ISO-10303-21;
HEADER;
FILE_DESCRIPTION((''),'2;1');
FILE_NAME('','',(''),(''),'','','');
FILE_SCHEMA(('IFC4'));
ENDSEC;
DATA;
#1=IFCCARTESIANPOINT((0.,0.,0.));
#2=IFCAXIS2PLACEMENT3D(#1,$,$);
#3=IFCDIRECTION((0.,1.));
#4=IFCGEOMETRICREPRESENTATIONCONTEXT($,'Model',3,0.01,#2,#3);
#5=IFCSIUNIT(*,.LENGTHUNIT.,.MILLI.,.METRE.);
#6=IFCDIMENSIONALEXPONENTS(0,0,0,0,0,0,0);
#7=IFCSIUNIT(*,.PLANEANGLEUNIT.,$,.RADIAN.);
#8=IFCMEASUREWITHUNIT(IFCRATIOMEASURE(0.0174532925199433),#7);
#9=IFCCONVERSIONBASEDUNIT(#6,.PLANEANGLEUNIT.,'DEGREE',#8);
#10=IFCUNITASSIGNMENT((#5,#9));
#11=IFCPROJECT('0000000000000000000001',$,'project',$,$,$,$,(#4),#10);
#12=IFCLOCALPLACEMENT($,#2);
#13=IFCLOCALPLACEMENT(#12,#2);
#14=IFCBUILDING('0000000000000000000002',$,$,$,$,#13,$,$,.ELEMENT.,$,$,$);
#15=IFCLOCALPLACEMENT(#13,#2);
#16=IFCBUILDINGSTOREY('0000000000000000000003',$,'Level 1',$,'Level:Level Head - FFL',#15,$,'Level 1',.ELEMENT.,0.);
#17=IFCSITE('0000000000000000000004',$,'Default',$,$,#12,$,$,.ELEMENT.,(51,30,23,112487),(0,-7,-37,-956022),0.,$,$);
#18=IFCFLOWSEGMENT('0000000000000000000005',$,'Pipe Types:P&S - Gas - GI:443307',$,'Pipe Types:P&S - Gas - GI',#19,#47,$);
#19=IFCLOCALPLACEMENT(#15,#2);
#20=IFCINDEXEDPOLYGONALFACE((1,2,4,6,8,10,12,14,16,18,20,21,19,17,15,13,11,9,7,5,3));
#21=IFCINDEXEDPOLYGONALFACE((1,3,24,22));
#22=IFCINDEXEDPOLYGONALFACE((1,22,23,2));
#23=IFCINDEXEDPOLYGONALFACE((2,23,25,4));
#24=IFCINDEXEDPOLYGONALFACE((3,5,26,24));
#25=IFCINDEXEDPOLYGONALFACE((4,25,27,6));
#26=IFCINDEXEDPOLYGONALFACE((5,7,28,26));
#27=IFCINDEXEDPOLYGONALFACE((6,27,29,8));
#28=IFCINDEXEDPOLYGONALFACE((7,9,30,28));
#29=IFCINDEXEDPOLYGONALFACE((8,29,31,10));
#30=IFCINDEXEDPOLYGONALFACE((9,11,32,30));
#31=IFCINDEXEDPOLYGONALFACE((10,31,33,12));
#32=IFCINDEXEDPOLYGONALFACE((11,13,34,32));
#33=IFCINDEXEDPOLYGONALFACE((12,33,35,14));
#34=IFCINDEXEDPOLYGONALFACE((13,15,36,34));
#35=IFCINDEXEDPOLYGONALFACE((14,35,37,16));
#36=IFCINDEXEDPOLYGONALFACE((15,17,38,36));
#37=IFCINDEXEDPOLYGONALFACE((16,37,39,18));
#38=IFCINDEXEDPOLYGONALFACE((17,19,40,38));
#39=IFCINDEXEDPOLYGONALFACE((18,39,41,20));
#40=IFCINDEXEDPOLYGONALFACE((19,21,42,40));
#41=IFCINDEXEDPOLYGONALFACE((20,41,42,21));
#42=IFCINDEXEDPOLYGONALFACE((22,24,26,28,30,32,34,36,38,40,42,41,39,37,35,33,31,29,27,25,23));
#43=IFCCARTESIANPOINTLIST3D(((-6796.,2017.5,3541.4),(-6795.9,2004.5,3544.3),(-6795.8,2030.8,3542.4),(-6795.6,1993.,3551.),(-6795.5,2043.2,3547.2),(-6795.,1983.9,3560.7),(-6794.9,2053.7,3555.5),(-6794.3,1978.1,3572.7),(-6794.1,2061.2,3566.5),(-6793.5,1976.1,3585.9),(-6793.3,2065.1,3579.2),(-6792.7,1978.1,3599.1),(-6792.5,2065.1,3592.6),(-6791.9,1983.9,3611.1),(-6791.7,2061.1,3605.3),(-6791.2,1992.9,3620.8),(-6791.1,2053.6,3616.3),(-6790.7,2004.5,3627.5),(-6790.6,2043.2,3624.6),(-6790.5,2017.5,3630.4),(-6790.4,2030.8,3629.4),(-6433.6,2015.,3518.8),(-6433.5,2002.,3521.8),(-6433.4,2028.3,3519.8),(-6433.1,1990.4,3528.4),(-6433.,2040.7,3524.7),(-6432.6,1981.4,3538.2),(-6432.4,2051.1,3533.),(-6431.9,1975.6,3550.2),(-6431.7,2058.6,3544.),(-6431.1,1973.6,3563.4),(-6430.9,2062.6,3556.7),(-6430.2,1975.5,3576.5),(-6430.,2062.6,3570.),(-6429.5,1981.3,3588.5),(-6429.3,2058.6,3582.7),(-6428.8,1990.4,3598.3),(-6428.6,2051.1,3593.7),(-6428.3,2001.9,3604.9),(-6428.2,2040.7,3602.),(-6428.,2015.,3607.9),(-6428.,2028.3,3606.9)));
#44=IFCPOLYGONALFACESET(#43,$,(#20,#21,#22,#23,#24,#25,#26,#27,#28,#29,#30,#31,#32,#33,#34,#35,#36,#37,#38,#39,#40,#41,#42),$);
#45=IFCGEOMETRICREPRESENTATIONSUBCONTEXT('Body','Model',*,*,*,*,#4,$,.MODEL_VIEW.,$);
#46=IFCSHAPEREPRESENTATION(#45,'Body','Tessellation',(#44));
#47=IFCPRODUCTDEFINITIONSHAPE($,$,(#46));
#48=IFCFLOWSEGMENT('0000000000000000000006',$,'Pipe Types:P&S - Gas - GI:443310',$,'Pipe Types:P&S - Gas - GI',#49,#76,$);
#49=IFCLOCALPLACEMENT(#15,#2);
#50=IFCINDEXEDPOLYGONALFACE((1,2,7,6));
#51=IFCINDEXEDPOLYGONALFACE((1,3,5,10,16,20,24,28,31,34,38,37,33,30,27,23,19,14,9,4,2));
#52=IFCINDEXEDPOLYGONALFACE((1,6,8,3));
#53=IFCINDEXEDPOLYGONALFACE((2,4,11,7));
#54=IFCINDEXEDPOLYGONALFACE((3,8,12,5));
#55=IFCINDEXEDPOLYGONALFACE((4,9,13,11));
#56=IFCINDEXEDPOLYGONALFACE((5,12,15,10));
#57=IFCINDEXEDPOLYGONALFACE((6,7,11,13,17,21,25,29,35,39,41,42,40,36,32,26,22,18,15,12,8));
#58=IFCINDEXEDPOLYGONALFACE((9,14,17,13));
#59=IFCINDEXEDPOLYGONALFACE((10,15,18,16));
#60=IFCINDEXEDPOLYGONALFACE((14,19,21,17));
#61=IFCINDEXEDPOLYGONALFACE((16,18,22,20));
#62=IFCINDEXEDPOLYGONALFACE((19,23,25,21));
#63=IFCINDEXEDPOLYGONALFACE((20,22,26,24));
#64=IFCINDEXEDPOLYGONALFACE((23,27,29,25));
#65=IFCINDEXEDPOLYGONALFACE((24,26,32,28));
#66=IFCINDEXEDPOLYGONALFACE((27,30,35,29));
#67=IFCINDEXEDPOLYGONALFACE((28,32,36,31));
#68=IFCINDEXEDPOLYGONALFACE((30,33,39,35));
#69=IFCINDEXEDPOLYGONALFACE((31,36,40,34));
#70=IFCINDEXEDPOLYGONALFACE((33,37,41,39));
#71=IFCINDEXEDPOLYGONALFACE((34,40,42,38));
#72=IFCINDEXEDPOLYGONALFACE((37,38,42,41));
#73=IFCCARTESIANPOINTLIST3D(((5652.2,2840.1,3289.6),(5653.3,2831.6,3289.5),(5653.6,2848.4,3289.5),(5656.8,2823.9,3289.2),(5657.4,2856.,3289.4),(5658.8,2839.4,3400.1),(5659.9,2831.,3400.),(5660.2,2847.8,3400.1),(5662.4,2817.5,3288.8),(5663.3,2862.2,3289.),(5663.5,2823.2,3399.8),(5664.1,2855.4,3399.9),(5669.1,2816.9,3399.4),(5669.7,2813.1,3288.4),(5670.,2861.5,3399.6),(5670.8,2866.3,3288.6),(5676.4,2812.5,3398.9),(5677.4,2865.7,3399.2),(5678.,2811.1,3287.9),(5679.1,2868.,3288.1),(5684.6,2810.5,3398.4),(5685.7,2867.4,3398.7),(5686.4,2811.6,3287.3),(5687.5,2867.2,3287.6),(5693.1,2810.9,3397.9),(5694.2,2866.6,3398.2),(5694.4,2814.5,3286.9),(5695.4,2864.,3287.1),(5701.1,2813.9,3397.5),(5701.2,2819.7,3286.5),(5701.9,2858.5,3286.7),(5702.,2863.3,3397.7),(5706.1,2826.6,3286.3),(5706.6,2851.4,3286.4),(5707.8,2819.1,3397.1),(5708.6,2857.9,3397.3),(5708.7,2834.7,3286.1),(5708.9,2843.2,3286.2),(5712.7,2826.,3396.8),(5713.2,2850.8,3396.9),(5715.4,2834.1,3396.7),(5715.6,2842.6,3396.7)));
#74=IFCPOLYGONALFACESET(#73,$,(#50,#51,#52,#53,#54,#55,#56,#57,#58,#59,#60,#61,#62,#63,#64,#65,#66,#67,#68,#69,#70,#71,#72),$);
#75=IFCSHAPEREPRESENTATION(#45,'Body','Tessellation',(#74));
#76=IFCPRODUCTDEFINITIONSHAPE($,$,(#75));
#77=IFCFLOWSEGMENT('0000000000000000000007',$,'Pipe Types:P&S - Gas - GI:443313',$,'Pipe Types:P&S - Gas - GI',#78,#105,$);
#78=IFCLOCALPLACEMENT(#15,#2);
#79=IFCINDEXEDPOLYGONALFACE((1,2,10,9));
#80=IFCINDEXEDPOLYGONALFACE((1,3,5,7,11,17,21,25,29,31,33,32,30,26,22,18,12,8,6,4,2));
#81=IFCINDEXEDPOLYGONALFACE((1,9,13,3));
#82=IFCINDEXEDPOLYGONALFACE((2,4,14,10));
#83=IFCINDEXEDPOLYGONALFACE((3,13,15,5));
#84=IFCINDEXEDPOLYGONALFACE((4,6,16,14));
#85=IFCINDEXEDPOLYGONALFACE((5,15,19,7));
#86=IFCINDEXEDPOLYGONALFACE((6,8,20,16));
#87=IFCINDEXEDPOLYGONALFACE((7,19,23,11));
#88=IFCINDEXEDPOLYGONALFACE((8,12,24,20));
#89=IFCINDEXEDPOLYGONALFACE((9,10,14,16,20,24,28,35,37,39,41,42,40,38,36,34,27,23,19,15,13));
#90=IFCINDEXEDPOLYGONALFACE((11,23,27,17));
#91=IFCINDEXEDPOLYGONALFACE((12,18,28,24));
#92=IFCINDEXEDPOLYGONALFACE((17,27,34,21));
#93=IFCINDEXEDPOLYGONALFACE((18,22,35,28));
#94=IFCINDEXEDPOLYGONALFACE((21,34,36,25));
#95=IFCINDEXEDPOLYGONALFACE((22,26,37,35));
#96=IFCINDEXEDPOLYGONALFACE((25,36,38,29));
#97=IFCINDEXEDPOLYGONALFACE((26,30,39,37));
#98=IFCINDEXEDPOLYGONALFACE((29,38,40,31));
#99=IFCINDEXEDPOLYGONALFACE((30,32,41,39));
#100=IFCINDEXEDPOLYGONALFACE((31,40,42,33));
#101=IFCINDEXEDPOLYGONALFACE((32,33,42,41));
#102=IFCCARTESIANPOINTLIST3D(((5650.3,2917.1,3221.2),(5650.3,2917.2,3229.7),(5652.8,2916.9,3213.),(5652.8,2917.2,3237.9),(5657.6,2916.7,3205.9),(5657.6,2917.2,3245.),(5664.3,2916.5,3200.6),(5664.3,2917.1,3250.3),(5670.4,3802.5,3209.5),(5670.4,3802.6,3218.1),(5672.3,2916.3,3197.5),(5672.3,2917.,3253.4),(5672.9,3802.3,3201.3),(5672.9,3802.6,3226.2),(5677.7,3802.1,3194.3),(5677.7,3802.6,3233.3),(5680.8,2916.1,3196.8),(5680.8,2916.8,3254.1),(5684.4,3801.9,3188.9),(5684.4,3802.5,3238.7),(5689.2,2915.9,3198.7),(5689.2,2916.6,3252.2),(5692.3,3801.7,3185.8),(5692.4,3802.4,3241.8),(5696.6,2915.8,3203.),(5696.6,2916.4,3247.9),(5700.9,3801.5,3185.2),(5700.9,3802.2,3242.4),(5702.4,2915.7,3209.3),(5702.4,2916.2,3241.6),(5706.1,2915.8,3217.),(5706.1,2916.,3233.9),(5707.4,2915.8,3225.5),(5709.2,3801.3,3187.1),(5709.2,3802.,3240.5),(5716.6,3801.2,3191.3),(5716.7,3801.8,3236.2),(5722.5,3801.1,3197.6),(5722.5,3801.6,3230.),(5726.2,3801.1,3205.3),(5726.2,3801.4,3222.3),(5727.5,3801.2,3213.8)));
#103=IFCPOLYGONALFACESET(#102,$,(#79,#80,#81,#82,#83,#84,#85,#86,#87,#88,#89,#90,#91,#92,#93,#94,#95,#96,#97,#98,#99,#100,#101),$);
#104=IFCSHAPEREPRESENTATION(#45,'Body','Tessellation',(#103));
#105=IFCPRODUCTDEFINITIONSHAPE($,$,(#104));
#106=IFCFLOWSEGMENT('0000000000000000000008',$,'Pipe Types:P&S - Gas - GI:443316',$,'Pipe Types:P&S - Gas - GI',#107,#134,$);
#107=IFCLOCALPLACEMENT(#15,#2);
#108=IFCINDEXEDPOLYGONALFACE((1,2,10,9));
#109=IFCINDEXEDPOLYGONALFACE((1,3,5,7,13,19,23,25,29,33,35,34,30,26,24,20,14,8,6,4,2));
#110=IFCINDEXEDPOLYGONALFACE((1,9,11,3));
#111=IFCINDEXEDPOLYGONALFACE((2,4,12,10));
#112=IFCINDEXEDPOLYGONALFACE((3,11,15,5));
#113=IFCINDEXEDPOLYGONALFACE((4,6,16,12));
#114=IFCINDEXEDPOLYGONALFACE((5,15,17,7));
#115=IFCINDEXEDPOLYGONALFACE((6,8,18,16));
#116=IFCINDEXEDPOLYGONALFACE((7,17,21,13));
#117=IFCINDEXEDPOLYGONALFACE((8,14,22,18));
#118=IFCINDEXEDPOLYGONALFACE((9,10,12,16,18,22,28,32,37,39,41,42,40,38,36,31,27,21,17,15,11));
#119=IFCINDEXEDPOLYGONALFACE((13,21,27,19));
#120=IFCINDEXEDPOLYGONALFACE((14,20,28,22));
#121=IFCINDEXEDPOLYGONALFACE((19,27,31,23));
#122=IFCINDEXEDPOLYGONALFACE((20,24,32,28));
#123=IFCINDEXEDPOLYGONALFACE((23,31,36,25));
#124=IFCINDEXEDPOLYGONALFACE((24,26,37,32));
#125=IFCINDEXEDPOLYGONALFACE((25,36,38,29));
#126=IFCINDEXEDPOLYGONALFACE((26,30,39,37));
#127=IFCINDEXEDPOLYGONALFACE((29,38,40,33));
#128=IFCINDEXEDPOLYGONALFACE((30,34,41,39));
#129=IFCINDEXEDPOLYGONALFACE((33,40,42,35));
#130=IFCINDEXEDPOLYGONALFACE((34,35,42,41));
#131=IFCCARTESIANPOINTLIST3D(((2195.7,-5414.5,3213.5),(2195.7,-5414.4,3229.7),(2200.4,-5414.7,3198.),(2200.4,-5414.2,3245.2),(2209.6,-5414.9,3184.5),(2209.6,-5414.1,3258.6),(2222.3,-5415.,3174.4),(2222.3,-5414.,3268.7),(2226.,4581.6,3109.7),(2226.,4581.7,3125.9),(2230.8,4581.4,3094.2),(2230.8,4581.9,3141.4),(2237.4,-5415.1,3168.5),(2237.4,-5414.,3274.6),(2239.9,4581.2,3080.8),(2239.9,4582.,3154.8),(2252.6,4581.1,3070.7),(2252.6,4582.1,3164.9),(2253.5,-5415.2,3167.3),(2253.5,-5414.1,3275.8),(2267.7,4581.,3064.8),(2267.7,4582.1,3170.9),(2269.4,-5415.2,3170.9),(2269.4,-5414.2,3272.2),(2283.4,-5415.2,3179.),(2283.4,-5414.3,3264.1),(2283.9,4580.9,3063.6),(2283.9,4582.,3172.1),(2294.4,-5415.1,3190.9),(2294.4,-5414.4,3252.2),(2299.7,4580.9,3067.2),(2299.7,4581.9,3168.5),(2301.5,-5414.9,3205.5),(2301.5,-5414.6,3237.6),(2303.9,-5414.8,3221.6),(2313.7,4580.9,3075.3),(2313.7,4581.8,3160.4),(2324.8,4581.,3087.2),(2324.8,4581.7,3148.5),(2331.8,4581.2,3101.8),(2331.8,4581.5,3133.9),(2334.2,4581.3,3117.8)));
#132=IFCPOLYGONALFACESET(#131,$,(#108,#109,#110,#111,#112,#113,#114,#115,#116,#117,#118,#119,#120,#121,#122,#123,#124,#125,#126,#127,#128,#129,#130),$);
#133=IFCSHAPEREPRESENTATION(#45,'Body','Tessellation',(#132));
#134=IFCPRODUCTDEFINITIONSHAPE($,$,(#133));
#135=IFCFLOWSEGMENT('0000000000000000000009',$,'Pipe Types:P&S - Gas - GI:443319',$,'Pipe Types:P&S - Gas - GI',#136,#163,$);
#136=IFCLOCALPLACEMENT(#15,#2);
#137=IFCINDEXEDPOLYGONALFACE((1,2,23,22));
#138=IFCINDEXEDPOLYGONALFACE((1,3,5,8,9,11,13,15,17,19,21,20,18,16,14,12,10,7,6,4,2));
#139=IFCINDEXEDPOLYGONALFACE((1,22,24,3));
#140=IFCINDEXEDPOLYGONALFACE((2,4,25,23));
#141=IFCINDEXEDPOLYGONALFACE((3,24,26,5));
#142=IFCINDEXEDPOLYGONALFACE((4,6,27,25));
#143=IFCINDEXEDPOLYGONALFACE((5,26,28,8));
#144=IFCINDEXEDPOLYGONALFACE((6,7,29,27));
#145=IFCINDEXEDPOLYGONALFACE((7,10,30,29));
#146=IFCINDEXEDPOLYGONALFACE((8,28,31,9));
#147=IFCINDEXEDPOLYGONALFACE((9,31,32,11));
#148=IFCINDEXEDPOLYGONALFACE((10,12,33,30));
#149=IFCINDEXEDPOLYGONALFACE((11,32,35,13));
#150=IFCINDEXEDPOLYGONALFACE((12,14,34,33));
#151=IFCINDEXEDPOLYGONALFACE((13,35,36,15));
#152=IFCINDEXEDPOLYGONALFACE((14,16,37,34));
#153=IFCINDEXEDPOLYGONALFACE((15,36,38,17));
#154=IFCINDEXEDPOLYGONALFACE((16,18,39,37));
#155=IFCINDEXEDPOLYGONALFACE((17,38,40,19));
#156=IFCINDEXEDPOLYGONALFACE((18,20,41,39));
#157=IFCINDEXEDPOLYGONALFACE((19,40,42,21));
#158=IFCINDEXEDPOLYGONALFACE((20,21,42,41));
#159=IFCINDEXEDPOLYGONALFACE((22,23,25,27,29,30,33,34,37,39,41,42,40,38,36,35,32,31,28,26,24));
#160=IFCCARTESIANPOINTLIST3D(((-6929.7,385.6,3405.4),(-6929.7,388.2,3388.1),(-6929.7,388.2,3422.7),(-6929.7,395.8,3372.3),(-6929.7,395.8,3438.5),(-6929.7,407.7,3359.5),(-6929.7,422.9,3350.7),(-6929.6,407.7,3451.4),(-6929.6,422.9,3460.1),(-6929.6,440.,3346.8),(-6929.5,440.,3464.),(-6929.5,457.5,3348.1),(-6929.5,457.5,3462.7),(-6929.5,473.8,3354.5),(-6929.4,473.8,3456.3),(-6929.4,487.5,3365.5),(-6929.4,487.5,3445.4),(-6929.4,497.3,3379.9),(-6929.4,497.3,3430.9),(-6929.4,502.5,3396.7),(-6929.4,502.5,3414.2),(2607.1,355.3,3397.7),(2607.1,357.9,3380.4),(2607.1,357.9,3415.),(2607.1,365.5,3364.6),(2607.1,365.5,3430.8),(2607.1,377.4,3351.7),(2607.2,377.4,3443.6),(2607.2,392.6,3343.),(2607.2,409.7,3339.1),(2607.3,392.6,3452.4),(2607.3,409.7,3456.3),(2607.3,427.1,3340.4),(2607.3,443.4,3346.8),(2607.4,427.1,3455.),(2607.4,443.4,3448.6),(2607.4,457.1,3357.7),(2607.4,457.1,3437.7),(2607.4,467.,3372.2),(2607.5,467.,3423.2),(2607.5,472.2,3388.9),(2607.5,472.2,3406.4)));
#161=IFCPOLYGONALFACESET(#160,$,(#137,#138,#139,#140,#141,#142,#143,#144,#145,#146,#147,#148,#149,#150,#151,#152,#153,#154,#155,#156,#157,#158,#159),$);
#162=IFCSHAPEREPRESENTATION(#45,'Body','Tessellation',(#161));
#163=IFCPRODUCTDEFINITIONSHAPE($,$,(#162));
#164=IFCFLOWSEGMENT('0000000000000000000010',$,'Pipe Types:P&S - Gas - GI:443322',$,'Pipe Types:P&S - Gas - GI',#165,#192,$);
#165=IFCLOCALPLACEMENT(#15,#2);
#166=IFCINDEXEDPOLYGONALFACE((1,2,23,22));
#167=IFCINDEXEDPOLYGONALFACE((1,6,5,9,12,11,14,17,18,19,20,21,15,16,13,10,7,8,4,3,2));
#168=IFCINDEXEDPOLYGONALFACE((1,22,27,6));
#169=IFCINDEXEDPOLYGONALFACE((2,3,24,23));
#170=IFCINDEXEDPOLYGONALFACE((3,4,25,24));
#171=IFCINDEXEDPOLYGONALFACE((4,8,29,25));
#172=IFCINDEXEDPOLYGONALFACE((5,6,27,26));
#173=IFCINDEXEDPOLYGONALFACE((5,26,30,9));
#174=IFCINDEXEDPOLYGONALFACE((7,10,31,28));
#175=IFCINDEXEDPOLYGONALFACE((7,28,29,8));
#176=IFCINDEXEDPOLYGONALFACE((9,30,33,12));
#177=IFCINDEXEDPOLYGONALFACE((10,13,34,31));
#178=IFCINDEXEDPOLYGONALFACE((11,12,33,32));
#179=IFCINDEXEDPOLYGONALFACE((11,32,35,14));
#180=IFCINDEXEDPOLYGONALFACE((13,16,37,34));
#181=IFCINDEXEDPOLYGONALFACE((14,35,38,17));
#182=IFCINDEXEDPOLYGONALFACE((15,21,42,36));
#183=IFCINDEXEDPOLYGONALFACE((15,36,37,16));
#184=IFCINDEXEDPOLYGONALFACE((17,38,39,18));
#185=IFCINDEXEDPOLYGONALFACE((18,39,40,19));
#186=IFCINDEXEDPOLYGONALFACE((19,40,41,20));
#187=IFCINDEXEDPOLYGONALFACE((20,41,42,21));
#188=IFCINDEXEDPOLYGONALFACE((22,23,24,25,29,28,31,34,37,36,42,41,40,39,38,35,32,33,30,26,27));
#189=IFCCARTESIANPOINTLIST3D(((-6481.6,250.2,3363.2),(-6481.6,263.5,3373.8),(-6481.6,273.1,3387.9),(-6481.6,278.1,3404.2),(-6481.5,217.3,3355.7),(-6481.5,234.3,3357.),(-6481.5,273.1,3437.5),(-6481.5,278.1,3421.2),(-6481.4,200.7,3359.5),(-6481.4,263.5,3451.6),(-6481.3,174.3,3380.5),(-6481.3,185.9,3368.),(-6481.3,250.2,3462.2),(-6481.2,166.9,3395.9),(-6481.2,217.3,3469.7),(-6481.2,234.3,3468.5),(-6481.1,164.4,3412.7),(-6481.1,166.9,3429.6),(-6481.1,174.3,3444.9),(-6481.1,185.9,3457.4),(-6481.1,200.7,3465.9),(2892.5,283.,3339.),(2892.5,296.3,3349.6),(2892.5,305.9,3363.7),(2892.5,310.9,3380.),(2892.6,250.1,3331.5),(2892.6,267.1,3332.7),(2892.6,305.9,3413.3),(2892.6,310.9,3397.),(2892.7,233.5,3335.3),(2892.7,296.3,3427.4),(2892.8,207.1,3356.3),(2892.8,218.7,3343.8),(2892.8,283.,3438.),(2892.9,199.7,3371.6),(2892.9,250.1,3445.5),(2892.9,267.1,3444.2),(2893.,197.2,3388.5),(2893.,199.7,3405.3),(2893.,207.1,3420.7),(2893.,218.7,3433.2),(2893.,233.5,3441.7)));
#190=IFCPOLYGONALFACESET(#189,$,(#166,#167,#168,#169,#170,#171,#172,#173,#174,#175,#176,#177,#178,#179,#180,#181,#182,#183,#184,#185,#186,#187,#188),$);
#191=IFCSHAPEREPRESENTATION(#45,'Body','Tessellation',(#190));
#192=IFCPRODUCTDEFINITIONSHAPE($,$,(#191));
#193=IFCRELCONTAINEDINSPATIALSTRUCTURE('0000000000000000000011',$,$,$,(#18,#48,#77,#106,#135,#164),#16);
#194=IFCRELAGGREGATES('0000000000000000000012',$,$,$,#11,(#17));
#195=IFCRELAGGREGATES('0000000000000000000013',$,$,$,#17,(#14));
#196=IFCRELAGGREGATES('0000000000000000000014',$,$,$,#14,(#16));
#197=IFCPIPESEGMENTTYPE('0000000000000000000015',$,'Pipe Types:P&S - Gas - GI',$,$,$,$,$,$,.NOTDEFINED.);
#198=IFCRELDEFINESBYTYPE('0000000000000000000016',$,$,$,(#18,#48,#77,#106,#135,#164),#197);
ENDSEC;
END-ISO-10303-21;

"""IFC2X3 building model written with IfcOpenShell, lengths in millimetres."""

from ifc_helpers import new_model, entity, si_unit, converted_unit, direction, frame, frame_2d, origin, origin_2d_with_axis, place, context, subcontext, project, spatial, circle, extrude, type_object, element, save


model = new_model("IFC2X3")

# Units and contexts
model_context = context("Model", 3, precision=0.01, world=origin(), true_north=direction((0.0, 1.0)))
body_context = subcontext(model_context, "Body", "Model", "MODEL_VIEW")
ifc_project = project(units=[si_unit("LENGTHUNIT", "METRE", prefix="MILLI"), converted_unit("PLANEANGLEUNIT", "DEGREE", entity("IfcRatioMeasure", 0.0174532925199433), si_unit("PLANEANGLEUNIT", "RADIAN"), dimensions=[0, 0, 0, 0, 0, 0, 0])], contexts=[model_context])

# Site, building, storey
site_placement = place(None, origin())
site = spatial("IfcSite", under=ifc_project, at=site_placement, Name="Default", CompositionType="ELEMENT", RefLatitude=(51, 30, 23, 112487), RefLongitude=(0, -7, -37, -956022), RefElevation=0.0)
building_placement = place(site_placement, origin())
building = spatial("IfcBuilding", under=site, at=building_placement, CompositionType="ELEMENT")
storey_placement = place(building_placement, origin())
storey = spatial("IfcBuildingStorey", under=building, at=storey_placement, Name="Level 1", ObjectType="Level:Level Head - FFL", LongName="Level 1", CompositionType="ELEMENT", Elevation=0.0)

# Flow segments
pipe_segment_type = type_object("IfcPipeSegmentType", Name="Pipe Types:P&S - Gas - GI", PredefinedType="NOTDEFINED")
flow_segment_1_placement = place(storey_placement, origin())
element("IfcFlowSegment", 1, at=flow_segment_1_placement, inside=storey, type_object=pipe_segment_type, Name="Pipe Types:P&S - Gas - GI:443307", ObjectType="Pipe Types:P&S - Gas - GI", context=body_context, shape_type="SweptSolid", body=[
    extrude(circle(Radius=44.7, at=frame_2d((0.0, 0.0), x_axis=(1.0, 0.0))), frame((-6430.8, 2018.3, 3563.4), z_axis=(-0.998046, 0.006954, 0.062101), x_axis=(-0.006967, -0.999976, 0.0)), (0.0, 0.0, 1.0), 363.2),
])
flow_segment_2_placement = place(storey_placement, origin())
element("IfcFlowSegment", 2, at=flow_segment_2_placement, inside=storey, type_object=pipe_segment_type, Name="Pipe Types:P&S - Gas - GI:443310", ObjectType="Pipe Types:P&S - Gas - GI", context=body_context, shape_type="SweptSolid", body=[
    extrude(circle(Radius=28.6, at=frame_2d((0.0, 0.0), x_axis=(1.0, 0.0))), frame((5687.3, 2838.9, 3398.4), z_axis=(-0.060153, 0.005672, -0.998173), x_axis=(-0.093871, -0.995584, 0.0)), (0.0, 0.0, 1.0), 110.8),
])
flow_segment_3_placement = place(storey_placement, origin())
element("IfcFlowSegment", 3, at=flow_segment_3_placement, inside=storey, type_object=pipe_segment_type, Name="Pipe Types:P&S - Gas - GI:443313", ObjectType="Pipe Types:P&S - Gas - GI", context=body_context, shape_type="SweptSolid", body=[
    extrude(circle(Radius=28.7, at=origin_2d_with_axis()), frame((5678.7, 2916.5, 3225.5), z_axis=(0.02265, 0.999657, -0.013169), x_axis=(0.999743, -0.022652, 0.0)), (0.0, 0.0, 1.0), 885.7),
])
flow_segment_4_placement = place(storey_placement, origin())
element("IfcFlowSegment", 4, at=flow_segment_4_placement, inside=storey, type_object=pipe_segment_type, Name="Pipe Types:P&S - Gas - GI:443316", ObjectType="Pipe Types:P&S - Gas - GI", context=body_context, shape_type="SweptSolid", body=[
    extrude(circle(Radius=54.4, at=origin_2d_with_axis()), frame((2249.5, -5414.6, 3221.6), z_axis=(0.003036, 0.999942, -0.010378), x_axis=(0.999995, -0.003036, 0.0)), (0.0, 0.0, 1.0), 9996.7),
])
flow_segment_5_placement = place(storey_placement, origin())
element("IfcFlowSegment", 5, at=flow_segment_5_placement, inside=storey, type_object=pipe_segment_type, Name="Pipe Types:P&S - Gas - GI:443319", ObjectType="Pipe Types:P&S - Gas - GI", context=body_context, shape_type="SweptSolid", body=[
    extrude(circle(Radius=58.8, at=frame_2d((0.0, 0.0), x_axis=(1.0, 0.0))), frame((-6929.5, 444.4, 3405.4), z_axis=(0.999995, -0.00318, -0.000812), x_axis=(-0.00318, -0.999995, 0.0)), (0.0, 0.0, 1.0), 9536.9),
])
flow_segment_6_placement = place(storey_placement, origin())
element("IfcFlowSegment", 6, at=flow_segment_6_placement, inside=storey, type_object=pipe_segment_type, Name="Pipe Types:P&S - Gas - GI:443322", ObjectType="Pipe Types:P&S - Gas - GI", context=body_context, shape_type="SweptSolid", body=[
    extrude(circle(Radius=57.2, at=frame_2d((0.0, 0.0), x_axis=(1.0, 0.0))), frame((-6481.3, 221.6, 3412.7), z_axis=(0.999991, 0.003498, -0.002584), x_axis=(0.003498, -0.999994, 0.0)), (0.0, 0.0, 1.0), 9374.2),
])

save(model, "model.ifc")
